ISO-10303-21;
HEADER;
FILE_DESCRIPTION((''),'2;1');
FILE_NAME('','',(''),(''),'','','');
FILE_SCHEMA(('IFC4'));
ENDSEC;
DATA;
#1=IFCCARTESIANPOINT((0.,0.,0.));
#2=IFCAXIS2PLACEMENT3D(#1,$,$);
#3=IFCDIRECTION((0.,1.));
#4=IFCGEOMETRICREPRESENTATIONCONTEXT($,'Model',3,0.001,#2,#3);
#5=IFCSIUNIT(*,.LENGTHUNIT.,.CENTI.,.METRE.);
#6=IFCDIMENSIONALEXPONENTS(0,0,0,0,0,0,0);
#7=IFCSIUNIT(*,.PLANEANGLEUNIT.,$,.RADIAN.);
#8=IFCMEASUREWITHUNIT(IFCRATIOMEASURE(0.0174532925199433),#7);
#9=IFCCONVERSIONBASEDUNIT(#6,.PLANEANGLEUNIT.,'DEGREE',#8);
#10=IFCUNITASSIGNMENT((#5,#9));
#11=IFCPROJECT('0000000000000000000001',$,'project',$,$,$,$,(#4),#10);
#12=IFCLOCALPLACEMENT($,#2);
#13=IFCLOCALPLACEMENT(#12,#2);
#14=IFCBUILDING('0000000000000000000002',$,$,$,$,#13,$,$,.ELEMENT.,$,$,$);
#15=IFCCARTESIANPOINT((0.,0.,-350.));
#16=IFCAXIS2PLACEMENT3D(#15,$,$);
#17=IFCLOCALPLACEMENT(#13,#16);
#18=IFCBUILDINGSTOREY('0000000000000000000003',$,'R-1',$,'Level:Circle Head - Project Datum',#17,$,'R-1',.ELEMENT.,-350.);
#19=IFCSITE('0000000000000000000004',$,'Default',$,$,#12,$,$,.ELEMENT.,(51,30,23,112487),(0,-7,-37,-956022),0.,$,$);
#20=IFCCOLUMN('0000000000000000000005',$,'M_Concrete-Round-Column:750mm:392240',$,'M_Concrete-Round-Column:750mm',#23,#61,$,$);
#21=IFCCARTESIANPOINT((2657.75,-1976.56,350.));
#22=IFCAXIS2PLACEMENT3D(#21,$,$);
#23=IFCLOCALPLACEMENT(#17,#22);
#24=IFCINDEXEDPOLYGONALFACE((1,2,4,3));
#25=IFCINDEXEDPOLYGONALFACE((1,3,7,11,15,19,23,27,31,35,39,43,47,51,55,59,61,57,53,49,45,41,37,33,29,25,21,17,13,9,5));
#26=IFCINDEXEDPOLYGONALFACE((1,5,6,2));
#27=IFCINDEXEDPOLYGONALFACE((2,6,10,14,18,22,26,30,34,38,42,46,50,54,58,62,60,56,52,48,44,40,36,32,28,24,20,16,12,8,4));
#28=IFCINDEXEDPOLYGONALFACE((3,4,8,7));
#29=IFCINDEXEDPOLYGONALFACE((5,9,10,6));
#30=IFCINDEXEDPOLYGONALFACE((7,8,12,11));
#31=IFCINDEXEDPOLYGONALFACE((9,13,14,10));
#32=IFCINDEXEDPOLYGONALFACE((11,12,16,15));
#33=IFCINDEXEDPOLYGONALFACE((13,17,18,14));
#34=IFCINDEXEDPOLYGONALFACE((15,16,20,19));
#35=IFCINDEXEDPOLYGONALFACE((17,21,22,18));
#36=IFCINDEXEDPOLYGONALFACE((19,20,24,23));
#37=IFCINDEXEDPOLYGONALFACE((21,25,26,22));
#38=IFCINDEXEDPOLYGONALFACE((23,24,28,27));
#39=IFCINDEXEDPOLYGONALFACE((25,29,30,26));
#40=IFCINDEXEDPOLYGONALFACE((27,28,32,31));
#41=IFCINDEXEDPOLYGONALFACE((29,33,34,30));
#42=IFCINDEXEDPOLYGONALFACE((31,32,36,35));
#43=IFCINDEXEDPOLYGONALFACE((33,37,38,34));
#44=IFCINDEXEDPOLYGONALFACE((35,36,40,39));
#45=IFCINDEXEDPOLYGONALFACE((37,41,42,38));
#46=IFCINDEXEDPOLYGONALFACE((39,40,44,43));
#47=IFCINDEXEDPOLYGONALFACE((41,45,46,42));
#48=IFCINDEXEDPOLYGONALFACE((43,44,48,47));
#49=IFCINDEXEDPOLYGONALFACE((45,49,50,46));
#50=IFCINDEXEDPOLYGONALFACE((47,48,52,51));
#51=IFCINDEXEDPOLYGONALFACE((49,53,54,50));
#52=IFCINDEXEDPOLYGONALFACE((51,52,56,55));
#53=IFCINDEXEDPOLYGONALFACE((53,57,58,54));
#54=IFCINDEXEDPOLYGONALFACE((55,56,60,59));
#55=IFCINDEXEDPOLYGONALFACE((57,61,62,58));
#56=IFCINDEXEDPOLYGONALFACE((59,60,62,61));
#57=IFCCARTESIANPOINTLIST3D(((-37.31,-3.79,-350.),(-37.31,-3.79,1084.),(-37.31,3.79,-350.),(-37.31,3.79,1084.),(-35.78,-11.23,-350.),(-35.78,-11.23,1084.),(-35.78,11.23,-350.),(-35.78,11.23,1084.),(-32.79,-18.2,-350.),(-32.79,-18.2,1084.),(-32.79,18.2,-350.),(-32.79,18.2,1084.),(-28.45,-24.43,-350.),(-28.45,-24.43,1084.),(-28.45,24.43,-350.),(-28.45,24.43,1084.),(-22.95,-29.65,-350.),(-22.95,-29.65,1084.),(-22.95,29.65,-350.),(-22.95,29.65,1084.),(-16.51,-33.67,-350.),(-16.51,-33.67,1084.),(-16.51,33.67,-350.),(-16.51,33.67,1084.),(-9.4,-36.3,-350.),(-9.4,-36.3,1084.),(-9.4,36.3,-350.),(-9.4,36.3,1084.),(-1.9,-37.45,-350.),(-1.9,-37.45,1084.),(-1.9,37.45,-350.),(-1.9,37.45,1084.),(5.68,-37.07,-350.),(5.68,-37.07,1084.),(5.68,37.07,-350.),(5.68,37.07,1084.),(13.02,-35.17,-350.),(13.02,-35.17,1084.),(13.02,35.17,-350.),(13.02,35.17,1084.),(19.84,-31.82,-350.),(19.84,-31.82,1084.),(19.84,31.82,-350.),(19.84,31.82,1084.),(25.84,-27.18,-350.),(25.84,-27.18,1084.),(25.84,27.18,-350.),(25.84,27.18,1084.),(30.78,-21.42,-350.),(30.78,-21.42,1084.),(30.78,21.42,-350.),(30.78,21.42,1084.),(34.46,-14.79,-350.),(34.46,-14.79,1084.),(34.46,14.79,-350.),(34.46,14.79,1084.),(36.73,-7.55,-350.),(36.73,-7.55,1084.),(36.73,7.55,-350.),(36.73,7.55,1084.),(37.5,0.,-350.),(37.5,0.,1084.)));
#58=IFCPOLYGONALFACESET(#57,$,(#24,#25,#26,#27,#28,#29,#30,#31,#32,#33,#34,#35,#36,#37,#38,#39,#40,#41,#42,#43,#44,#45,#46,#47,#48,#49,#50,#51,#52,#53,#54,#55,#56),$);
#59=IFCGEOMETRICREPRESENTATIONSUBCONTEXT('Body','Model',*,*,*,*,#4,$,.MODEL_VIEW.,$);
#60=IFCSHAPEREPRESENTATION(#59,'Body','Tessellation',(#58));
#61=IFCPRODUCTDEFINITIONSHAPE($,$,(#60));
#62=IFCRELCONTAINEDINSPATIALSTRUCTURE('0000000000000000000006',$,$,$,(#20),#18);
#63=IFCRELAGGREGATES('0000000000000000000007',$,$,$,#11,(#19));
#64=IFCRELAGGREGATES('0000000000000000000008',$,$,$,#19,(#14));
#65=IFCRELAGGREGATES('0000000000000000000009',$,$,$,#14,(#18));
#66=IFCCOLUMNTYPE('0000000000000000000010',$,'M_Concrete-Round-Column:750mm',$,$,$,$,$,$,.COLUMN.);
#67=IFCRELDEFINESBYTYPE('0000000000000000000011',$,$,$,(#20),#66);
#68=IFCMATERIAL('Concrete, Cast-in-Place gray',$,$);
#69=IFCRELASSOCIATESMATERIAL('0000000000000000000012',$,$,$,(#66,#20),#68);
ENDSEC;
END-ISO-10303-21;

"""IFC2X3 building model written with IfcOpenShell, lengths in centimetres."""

from ifc_helpers import new_model, entity, si_unit, converted_unit, direction, frame, frame_2d, origin, place, context, subcontext, project, spatial, circle, extrude, source, transform, mapped, material, type_object, type_shapes, element, save


model = new_model("IFC2X3")

# Units and contexts
model_context = context("Model", 3, precision=0.001, world=origin(), true_north=direction((0.0, 1.0)))
body_context = subcontext(model_context, "Body", "Model", "MODEL_VIEW")
ifc_project = project(units=[si_unit("LENGTHUNIT", "METRE", prefix="CENTI"), converted_unit("PLANEANGLEUNIT", "DEGREE", entity("IfcRatioMeasure", 0.0174532925199433), si_unit("PLANEANGLEUNIT", "RADIAN"), dimensions=[0, 0, 0, 0, 0, 0, 0])], contexts=[model_context])

# Site, building, storey
site_placement = place(None, origin())
site = spatial("IfcSite", under=ifc_project, at=site_placement, Name="Default", CompositionType="ELEMENT", RefLatitude=(51, 30, 23, 112487), RefLongitude=(0, -7, -37, -956022), RefElevation=0.0)
building_placement = place(site_placement, origin())
building = spatial("IfcBuilding", under=site, at=building_placement, CompositionType="ELEMENT")
storey_placement = place(building_placement, frame((0.0, 0.0, -350.0)))
storey = spatial("IfcBuildingStorey", under=building, at=storey_placement, Name="R-1", ObjectType="Level:Circle Head - Project Datum", LongName="R-1", CompositionType="ELEMENT", Elevation=-350.0)

# Column
ifc_material_1 = material(Name="Concrete, Cast-in-Place gray")
column_type_1 = type_object("IfcColumnType", Name="M_Concrete-Round-Column:750mm", PredefinedType="COLUMN", material=ifc_material_1)
shared_shape_1 = source(origin(), body_context, "Body", "SweptSolid", [
    extrude(circle(Radius=37.5, at=frame_2d((0.0, 0.0), x_axis=(1.0, 0.0))), frame((0.0, 0.0, -350.0)), (0.0, 0.0, 1.0), 1434.0),
])
type_shapes(column_type_1, [shared_shape_1])
column_placement = place(storey_placement, frame((2657.75, -1976.56, 350.0)))
element("IfcColumn", 1, at=column_placement, inside=storey, type_object=column_type_1, material=ifc_material_1, Name="M_Concrete-Round-Column:750mm:392240", ObjectType="M_Concrete-Round-Column:750mm", context=body_context, shape_type="MappedRepresentation", body=[
    mapped(shared_shape_1, transform((0.0, 0.0, 0.0), scale=1.0)),
])

save(model, "model.ifc")
